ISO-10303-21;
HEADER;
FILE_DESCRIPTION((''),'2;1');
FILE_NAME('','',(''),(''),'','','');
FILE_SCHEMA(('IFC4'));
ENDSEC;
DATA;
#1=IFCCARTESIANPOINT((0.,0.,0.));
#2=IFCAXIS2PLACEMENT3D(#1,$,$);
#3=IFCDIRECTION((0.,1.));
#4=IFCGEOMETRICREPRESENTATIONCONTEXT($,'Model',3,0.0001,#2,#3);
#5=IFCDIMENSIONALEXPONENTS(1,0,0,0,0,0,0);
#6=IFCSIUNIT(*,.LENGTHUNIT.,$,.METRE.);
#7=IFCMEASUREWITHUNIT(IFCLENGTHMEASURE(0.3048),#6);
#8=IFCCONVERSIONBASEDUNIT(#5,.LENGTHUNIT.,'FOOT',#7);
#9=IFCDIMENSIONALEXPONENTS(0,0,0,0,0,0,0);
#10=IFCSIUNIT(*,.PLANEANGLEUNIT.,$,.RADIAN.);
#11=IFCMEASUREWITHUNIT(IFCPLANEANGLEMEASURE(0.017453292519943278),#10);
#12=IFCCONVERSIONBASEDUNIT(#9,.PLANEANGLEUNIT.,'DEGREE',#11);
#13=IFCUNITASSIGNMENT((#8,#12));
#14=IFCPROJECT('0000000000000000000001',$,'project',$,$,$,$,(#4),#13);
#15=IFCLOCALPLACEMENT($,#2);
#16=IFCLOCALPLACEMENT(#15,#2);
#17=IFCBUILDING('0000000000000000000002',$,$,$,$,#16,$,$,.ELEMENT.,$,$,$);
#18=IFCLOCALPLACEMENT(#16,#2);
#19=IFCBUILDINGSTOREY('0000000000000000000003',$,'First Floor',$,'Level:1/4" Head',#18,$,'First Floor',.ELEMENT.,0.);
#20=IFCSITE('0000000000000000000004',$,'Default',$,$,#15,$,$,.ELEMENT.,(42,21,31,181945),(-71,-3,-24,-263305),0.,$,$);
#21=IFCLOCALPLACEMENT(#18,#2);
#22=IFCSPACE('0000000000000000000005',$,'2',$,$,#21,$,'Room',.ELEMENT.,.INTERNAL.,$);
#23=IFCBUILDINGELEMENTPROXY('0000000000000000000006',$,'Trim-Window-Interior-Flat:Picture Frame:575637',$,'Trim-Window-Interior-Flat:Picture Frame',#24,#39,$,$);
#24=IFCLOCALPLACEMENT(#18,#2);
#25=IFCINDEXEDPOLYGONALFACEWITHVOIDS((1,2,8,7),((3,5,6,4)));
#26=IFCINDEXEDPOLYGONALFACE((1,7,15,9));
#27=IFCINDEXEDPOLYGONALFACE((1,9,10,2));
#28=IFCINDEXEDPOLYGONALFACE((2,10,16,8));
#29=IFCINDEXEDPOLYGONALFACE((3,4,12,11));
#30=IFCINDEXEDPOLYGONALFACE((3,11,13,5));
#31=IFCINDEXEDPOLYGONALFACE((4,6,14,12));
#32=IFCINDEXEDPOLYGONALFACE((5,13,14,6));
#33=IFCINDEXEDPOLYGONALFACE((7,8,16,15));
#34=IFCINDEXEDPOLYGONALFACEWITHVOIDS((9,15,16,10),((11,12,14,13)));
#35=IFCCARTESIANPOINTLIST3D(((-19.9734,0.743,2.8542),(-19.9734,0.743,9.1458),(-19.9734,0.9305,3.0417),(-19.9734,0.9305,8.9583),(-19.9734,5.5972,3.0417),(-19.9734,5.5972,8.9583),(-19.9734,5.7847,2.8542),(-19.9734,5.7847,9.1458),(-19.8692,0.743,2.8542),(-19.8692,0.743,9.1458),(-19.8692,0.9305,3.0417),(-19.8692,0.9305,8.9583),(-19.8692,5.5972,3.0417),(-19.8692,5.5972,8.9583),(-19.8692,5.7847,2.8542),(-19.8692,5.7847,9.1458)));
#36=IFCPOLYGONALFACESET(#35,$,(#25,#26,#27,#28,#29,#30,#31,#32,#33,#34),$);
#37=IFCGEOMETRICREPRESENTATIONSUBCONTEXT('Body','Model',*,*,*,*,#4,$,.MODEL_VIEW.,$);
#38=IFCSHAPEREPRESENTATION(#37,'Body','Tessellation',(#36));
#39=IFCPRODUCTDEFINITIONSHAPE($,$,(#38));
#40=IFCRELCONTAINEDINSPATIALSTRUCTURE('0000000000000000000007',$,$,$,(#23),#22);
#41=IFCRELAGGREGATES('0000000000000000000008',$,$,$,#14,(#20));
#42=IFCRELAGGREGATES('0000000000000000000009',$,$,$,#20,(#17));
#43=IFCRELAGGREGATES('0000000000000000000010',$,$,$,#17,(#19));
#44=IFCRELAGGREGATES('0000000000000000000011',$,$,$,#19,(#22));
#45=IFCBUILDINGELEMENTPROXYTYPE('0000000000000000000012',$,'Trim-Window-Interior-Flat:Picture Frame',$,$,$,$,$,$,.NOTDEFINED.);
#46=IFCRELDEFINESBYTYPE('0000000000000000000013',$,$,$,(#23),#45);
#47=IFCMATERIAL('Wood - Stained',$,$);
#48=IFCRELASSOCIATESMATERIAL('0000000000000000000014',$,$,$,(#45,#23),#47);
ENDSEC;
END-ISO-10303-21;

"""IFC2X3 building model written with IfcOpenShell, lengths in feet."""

from ifc_helpers import new_model, entity, si_unit, converted_unit, direction, frame, origin, place, context, subcontext, project, spatial, polyline, outline, extrude, source, transform, mapped, material, type_object, type_shapes, element, save


model = new_model("IFC2X3")

# Units and contexts
model_context = context("Model", 3, precision=0.0001, world=origin(), true_north=direction((0.0, 1.0)))
body_context = subcontext(model_context, "Body", "Model", "MODEL_VIEW")
ifc_project = project(units=[converted_unit("LENGTHUNIT", "FOOT", entity("IfcLengthMeasure", 0.3048), si_unit("LENGTHUNIT", "METRE"), dimensions=[1, 0, 0, 0, 0, 0, 0]), converted_unit("PLANEANGLEUNIT", "DEGREE", entity("IfcPlaneAngleMeasure", 0.017453292519943278), si_unit("PLANEANGLEUNIT", "RADIAN"), dimensions=[0, 0, 0, 0, 0, 0, 0])], contexts=[model_context])

# Site, building, storey
site_placement = place(None, origin())
site = spatial("IfcSite", under=ifc_project, at=site_placement, Name="Default", CompositionType="ELEMENT", RefLatitude=(42, 21, 31, 181945), RefLongitude=(-71, -3, -24, -263305), RefElevation=0.0)
building_placement = place(site_placement, origin())
building = spatial("IfcBuilding", under=site, at=building_placement, CompositionType="ELEMENT")
storey_placement = place(building_placement, origin())
storey = spatial("IfcBuildingStorey", under=building, at=storey_placement, Name="First Floor", ObjectType="Level:1/4\" Head", LongName="First Floor", CompositionType="ELEMENT", Elevation=0.0)

# Shared definitions
space_placement = place(storey_placement, origin())
space = spatial("IfcSpace", under=storey, at=space_placement, Name="2", LongName="Room", CompositionType="ELEMENT", InteriorOrExteriorSpace="INTERNAL")

# Building element proxy
ifc_material_1 = material(Name="Wood - Stained")
building_element_proxy_type_1 = type_object("IfcBuildingElementProxyType", Name="Trim-Window-Interior-Flat:Picture Frame", PredefinedType="NOTDEFINED", material=ifc_material_1)
shared_shape_1 = source(origin(), body_context, "Body", "SweptSolid", [
    extrude(outline(polyline([(-3.1458, -2.5208), (3.1458, -2.5208), (3.1458, 2.5208), (-3.1458, 2.5208), (-3.1458, -2.5208)]), holes=[polyline([(-2.9583, -2.3333), (-2.9583, 2.3333), (2.9583, 2.3333), (2.9583, -2.3333), (-2.9583, -2.3333)])]), frame((0.0, 3.0, 0.0), z_axis=(0.0, 0.0, 1.0), x_axis=(0.0, 1.0, 0.0)), (0.0, 0.0, 1.0), 0.1042),
])
type_shapes(building_element_proxy_type_1, [shared_shape_1])
proxy_1_placement = place(space_placement, frame((-19.9734, 3.2639, 9.0), z_axis=(1.0, 0.0, 0.0), x_axis=(0.0, -1.0, 0.0)))
element("IfcBuildingElementProxy", 1, at=proxy_1_placement, inside=space, type_object=building_element_proxy_type_1, material=ifc_material_1, Name="Trim-Window-Interior-Flat:Picture Frame:575637", ObjectType="Trim-Window-Interior-Flat:Picture Frame", context=body_context, shape_type="MappedRepresentation", body=[
    mapped(shared_shape_1, transform((0.0, 0.0, 0.0), scale=1.0)),
])

save(model, "model.ifc")
